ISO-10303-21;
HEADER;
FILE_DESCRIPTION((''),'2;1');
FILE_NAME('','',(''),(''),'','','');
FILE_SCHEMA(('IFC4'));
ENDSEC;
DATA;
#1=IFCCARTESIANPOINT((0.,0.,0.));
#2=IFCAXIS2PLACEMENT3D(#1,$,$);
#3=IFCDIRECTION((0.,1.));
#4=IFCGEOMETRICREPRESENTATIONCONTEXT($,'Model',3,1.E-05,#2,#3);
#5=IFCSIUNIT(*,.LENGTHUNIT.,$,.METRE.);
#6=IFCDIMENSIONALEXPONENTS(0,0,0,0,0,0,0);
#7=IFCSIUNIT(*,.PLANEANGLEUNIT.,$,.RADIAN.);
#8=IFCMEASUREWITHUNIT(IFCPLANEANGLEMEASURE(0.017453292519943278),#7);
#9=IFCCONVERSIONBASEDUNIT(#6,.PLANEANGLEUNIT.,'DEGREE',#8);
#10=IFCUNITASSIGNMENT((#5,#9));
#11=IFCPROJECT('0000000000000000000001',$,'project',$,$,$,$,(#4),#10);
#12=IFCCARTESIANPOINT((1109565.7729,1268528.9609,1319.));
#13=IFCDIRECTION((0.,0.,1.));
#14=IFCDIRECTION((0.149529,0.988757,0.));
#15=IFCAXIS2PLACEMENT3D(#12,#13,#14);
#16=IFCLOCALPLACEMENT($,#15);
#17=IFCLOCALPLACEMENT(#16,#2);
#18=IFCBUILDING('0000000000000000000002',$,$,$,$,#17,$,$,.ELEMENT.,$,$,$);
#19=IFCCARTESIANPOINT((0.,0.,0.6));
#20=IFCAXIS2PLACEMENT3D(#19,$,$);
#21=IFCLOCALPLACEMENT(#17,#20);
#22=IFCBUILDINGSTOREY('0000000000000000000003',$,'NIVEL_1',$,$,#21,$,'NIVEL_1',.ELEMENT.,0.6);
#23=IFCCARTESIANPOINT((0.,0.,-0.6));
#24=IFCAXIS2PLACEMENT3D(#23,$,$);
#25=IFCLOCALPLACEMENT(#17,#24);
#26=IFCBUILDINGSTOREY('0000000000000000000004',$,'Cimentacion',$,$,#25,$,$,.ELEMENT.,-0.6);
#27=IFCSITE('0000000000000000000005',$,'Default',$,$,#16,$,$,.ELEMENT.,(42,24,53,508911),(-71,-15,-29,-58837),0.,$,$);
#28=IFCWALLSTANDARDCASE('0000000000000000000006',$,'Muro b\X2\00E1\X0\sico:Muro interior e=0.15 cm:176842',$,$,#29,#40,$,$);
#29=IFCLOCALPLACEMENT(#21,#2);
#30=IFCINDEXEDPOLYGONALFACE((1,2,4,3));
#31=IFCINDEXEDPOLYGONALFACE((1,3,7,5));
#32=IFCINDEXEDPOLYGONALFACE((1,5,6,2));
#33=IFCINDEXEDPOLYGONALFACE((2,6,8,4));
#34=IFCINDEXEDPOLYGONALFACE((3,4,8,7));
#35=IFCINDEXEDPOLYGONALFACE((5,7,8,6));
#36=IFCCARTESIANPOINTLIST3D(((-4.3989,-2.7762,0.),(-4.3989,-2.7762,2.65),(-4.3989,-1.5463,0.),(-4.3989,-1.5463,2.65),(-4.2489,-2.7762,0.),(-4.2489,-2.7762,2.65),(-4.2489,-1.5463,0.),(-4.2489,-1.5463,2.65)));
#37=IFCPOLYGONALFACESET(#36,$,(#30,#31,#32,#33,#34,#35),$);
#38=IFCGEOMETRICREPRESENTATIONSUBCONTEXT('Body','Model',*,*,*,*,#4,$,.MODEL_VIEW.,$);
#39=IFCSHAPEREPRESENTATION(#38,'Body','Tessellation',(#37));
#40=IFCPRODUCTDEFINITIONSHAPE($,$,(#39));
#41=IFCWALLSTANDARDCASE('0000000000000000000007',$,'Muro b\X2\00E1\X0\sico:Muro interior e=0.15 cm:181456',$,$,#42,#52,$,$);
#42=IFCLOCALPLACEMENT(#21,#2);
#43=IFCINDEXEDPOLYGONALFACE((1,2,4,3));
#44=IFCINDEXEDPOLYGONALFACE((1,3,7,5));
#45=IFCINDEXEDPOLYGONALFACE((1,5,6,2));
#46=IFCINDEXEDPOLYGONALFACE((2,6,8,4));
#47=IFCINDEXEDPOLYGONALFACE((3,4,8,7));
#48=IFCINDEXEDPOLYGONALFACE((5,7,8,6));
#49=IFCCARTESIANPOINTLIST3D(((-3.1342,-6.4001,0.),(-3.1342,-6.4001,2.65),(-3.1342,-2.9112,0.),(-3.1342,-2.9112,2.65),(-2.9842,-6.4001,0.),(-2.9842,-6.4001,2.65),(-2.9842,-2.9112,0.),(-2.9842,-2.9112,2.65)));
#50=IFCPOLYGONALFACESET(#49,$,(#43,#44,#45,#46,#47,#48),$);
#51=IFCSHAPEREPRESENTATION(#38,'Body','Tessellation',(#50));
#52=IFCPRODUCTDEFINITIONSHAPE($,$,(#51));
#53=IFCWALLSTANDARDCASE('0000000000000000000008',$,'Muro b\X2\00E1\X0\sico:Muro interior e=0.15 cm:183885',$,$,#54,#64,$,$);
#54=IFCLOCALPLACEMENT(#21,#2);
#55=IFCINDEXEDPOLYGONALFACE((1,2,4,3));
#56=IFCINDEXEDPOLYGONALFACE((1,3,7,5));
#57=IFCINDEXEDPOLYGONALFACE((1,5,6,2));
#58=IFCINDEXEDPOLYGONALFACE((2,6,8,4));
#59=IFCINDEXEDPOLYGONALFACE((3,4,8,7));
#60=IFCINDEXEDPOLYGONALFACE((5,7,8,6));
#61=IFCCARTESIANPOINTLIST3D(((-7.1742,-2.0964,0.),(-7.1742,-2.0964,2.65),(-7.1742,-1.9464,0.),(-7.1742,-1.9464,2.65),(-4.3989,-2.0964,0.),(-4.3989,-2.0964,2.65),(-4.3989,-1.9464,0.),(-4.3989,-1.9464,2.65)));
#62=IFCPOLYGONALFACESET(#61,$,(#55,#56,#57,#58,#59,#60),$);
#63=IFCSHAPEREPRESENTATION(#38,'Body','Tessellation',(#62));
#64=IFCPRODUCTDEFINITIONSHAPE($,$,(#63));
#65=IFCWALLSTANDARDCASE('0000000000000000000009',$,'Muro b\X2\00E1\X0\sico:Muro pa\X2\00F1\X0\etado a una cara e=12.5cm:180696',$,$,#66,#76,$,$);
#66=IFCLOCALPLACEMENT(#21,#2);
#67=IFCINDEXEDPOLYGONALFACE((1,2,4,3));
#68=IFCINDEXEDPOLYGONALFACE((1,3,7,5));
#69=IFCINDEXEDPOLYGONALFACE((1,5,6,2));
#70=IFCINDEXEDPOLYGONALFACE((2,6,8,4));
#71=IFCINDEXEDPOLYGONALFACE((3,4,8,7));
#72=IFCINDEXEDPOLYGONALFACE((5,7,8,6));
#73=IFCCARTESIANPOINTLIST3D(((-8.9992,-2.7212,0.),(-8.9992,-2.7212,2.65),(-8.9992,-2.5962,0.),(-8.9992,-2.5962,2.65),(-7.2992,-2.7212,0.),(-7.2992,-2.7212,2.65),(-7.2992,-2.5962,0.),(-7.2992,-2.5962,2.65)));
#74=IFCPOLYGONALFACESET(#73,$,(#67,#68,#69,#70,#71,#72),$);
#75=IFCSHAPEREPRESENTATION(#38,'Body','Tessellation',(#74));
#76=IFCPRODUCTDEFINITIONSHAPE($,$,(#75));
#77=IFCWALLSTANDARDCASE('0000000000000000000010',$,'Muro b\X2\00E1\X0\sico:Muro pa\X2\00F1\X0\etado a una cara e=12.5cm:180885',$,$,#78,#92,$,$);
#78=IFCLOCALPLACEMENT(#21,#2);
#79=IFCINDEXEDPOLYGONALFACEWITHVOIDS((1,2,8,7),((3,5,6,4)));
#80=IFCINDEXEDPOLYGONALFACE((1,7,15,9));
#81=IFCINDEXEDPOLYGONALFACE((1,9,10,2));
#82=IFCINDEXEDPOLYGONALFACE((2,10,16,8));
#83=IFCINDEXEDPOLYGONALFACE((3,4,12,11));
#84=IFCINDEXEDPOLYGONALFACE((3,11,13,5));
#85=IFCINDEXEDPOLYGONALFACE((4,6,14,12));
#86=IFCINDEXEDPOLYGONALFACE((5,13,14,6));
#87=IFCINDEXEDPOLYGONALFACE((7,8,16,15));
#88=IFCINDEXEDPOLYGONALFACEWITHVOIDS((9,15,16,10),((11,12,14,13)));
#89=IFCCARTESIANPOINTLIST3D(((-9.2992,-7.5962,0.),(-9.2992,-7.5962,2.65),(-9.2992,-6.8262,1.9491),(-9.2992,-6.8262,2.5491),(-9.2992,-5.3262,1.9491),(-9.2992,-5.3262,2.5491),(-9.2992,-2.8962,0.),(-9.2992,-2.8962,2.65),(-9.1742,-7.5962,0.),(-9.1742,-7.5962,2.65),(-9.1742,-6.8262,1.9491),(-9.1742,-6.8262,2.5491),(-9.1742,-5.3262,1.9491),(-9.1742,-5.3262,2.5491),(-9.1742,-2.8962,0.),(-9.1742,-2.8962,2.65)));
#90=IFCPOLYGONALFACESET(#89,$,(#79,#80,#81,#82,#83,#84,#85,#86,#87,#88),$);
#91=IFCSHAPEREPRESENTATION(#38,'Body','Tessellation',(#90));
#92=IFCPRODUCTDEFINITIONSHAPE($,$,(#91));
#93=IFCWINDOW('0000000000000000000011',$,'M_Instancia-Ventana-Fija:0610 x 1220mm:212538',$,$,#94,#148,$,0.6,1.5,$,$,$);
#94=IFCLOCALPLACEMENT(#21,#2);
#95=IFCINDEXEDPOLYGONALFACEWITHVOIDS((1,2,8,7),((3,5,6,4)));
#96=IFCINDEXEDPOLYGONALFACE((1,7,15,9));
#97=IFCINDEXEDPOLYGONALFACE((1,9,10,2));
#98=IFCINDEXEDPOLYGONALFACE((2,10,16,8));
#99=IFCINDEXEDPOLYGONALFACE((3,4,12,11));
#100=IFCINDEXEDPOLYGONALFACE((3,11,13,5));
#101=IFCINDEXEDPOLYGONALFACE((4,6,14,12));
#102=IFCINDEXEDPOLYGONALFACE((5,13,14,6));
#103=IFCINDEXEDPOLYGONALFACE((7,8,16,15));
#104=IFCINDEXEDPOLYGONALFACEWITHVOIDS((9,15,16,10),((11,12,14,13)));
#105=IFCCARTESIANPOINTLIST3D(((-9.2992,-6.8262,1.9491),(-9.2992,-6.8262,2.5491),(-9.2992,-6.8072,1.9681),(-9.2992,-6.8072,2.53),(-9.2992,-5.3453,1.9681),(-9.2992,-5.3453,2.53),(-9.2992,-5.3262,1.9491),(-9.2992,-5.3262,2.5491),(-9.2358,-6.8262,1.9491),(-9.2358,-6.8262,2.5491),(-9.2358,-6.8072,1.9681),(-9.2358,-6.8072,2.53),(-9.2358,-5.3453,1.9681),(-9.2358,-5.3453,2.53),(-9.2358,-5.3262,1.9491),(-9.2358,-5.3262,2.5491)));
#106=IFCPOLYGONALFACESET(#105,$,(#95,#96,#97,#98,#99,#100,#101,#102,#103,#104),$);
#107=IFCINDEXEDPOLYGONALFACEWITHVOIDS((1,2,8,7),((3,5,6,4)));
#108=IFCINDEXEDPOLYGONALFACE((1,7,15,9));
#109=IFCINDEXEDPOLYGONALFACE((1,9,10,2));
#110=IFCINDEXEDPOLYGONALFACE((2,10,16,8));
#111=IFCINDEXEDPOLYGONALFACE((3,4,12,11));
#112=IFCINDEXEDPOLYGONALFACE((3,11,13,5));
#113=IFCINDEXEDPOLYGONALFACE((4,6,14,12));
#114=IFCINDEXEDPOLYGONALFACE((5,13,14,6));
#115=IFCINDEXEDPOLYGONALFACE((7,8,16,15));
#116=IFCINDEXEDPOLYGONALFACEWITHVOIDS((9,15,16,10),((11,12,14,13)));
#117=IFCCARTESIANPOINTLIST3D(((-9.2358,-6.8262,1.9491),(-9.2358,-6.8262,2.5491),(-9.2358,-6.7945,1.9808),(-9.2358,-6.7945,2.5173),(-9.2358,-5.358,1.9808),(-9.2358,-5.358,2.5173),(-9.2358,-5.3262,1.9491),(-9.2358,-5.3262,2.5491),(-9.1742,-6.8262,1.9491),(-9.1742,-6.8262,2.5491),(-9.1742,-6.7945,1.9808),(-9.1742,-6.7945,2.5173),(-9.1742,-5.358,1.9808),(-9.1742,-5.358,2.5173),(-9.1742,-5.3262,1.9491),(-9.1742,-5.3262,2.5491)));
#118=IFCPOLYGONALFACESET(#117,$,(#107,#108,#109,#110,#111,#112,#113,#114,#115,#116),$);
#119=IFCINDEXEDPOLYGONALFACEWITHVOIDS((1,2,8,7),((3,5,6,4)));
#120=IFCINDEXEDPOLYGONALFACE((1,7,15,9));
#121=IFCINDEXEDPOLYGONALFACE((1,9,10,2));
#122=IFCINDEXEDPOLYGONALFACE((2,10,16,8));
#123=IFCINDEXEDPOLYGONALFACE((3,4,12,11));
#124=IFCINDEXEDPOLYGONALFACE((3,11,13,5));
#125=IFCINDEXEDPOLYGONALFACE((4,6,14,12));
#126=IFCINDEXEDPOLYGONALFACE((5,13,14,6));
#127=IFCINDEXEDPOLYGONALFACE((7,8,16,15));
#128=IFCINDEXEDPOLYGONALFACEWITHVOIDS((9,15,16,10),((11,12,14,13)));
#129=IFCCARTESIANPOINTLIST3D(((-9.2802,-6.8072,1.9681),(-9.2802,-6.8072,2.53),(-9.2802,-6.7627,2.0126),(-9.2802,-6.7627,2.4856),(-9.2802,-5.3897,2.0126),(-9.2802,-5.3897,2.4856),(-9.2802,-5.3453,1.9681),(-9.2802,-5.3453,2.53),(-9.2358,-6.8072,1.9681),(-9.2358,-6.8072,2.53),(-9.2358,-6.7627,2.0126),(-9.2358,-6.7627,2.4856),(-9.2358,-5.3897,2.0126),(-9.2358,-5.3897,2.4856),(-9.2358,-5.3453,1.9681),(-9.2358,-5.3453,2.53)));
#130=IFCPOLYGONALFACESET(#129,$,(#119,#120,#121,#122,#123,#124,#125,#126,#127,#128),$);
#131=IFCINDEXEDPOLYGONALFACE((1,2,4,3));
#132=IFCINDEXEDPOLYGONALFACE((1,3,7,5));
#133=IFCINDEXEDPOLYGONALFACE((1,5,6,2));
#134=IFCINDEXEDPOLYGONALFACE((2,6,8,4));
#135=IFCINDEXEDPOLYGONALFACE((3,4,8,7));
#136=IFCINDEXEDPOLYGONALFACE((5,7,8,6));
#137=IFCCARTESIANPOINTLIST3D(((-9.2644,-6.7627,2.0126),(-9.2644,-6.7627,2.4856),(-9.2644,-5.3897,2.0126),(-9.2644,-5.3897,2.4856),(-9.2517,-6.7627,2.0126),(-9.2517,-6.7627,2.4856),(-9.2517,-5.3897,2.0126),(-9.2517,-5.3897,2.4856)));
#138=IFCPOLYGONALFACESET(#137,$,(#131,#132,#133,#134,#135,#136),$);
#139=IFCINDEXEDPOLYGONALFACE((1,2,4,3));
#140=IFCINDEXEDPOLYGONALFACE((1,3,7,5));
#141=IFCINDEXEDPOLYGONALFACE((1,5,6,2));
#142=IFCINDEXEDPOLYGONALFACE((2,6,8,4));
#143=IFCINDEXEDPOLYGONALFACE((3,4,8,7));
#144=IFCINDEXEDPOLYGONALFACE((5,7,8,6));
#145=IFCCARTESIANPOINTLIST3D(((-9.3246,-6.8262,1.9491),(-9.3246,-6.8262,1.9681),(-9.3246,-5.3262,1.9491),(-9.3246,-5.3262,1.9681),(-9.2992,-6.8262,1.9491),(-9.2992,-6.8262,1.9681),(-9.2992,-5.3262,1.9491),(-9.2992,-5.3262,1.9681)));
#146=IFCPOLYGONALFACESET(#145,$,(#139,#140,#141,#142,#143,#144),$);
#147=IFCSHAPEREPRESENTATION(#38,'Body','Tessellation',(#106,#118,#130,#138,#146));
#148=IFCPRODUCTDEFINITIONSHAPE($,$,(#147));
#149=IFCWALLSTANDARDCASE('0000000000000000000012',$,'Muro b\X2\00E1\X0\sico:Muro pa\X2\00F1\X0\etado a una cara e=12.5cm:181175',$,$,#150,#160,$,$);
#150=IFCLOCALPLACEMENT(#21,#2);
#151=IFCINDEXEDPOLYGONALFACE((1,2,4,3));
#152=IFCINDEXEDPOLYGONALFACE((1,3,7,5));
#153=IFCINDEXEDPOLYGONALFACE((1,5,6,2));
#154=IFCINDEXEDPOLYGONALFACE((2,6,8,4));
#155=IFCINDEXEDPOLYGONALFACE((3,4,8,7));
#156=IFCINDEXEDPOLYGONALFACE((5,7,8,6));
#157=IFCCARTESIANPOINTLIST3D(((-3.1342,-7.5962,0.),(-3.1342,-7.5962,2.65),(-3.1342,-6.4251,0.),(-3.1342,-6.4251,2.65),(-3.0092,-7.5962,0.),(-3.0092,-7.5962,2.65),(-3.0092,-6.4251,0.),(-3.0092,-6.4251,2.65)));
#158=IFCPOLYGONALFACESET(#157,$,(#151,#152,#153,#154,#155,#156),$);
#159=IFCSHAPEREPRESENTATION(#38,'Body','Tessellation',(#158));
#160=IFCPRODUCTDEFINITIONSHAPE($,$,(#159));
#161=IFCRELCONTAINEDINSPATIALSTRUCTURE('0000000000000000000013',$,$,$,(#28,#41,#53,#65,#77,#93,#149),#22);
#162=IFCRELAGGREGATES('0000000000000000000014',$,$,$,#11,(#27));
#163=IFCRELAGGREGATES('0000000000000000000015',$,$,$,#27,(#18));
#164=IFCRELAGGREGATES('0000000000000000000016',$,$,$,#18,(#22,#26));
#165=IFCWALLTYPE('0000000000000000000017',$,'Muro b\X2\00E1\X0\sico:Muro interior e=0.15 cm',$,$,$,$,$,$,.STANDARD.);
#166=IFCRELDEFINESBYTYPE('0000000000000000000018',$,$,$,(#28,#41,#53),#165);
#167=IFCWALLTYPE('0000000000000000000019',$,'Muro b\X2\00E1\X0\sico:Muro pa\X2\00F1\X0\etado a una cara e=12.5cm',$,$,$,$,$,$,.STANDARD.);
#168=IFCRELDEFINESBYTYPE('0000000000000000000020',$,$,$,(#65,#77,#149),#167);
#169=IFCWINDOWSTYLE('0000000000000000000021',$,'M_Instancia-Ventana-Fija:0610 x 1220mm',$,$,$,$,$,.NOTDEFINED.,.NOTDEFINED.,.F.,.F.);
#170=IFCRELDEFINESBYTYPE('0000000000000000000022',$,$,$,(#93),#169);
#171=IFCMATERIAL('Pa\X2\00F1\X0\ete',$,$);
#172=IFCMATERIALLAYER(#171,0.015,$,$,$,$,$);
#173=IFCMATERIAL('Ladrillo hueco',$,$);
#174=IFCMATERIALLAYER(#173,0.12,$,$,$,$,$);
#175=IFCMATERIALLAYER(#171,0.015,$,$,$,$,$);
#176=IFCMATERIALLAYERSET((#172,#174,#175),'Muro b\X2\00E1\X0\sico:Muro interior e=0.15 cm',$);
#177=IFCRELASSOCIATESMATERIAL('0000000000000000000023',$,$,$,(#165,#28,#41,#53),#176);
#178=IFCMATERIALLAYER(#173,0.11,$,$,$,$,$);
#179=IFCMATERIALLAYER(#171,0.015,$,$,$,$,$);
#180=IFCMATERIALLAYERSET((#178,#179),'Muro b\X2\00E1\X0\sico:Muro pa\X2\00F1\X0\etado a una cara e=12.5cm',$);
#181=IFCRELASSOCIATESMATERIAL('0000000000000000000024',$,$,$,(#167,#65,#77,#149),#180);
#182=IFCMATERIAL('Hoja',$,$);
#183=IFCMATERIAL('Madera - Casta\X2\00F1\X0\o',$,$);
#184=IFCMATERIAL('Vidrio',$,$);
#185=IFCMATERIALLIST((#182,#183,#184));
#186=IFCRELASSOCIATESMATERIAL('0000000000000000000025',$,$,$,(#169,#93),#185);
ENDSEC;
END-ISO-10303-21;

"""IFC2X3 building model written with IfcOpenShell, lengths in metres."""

from ifc_helpers import new_model, entity, si_unit, converted_unit, direction, frame, frame_2d, origin, origin_2d_with_axis, place, context, subcontext, project, spatial, polyline, rectangle, outline, extrude, source, transform, mapped, material, material_list, layer, layer_set, layer_usage, type_object, type_shapes, element, fill, save


model = new_model("IFC2X3")

# Units and contexts
model_context = context("Model", 3, precision=1e-05, world=origin(), true_north=direction((0.0, 1.0)))
body_context = subcontext(model_context, "Body", "Model", "MODEL_VIEW")
ifc_project = project(units=[si_unit("LENGTHUNIT", "METRE"), converted_unit("PLANEANGLEUNIT", "DEGREE", entity("IfcPlaneAngleMeasure", 0.017453292519943278), si_unit("PLANEANGLEUNIT", "RADIAN"), dimensions=[0, 0, 0, 0, 0, 0, 0])], contexts=[model_context])

# Site, building, storey
site_placement = place(None, frame((1109565.7729, 1268528.9609, 1319.0), z_axis=(0.0, 0.0, 1.0), x_axis=(0.149529, 0.988757, 0.0)))
site = spatial("IfcSite", under=ifc_project, at=site_placement, Name="Default", CompositionType="ELEMENT", RefLatitude=(42, 24, 53, 508911), RefLongitude=(-71, -15, -29, -58837), RefElevation=0.0)
building_placement = place(site_placement, origin())
building = spatial("IfcBuilding", under=site, at=building_placement, CompositionType="ELEMENT")
storey_1_placement = place(building_placement, frame((0.0, 0.0, 0.6)))
storey_1 = spatial("IfcBuildingStorey", under=building, at=storey_1_placement, Name="NIVEL_1", LongName="NIVEL_1", CompositionType="ELEMENT", Elevation=0.6)

# Walls
ifc_material_1 = material(Name="Pañete")
ifc_layer_1 = layer(ifc_material_1, 0.015)
ifc_material_2 = material(Name="Ladrillo hueco")
ifc_layer_2 = layer(ifc_material_2, 0.12)
ifc_layer_3 = layer(ifc_material_1, 0.015)
ifc_layer_set_1 = layer_set([ifc_layer_1, ifc_layer_2, ifc_layer_3], Name="Muro básico:Muro interior e=0.15 cm")
ifc_layer_usage_1 = layer_usage(ifc_layer_set_1, "AXIS2", "POSITIVE", -0.075)
wall_type_1 = type_object("IfcWallType", Name="Muro básico:Muro interior e=0.15 cm", PredefinedType="STANDARD", material=ifc_layer_set_1)
wall_1_placement = place(storey_1_placement, frame((-4.3239, -2.7762, 0.0), z_axis=(0.0, 0.0, 1.0), x_axis=(0.0, 1.0, 0.0)))
element("IfcWallStandardCase", 1, at=wall_1_placement, inside=storey_1, type_object=wall_type_1, material=ifc_layer_usage_1, Name="Muro básico:Muro interior e=0.15 cm:176842", context=body_context, shape_type="SweptSolid", body=[
    extrude(rectangle(XDim=1.2299, YDim=0.15, at=frame_2d((0.6149, 0.0), x_axis=(-1.0, 0.0))), origin(), (0.0, 0.0, 1.0), 2.65),
])
ifc_layer_usage_2 = layer_usage(ifc_layer_set_1, "AXIS2", "POSITIVE", -0.075)
wall_2_placement = place(storey_1_placement, frame((-3.0592, -6.4001, 0.0), z_axis=(0.0, 0.0, 1.0), x_axis=(0.0, 1.0, 0.0)))
element("IfcWallStandardCase", 2, at=wall_2_placement, inside=storey_1, type_object=wall_type_1, material=ifc_layer_usage_2, Name="Muro básico:Muro interior e=0.15 cm:181456", context=body_context, shape_type="SweptSolid", body=[
    extrude(rectangle(XDim=3.4889, YDim=0.15, at=frame_2d((1.7445, 0.0), x_axis=(-1.0, 0.0))), origin(), (0.0, 0.0, 1.0), 2.65),
])
ifc_layer_usage_3 = layer_usage(ifc_layer_set_1, "AXIS2", "NEGATIVE", 0.075)
wall_3_placement = place(storey_1_placement, frame((-4.3989, -2.0214, 0.0), z_axis=(0.0, 0.0, 1.0), x_axis=(-1.0, 0.0, 0.0)))
element("IfcWallStandardCase", 3, at=wall_3_placement, inside=storey_1, type_object=wall_type_1, material=ifc_layer_usage_3, Name="Muro básico:Muro interior e=0.15 cm:183885", context=body_context, shape_type="SweptSolid", body=[
    extrude(rectangle(XDim=2.7754, YDim=0.15, at=frame_2d((1.3877, 0.0), x_axis=(-1.0, 0.0))), origin(), (0.0, 0.0, 1.0), 2.65),
])
ifc_layer_4 = layer(ifc_material_2, 0.11)
ifc_layer_5 = layer(ifc_material_1, 0.015)
ifc_layer_set_2 = layer_set([ifc_layer_4, ifc_layer_5], Name="Muro básico:Muro pañetado a una cara e=12.5cm")
ifc_layer_usage_4 = layer_usage(ifc_layer_set_2, "AXIS2", "POSITIVE", -0.0625)
wall_type_2 = type_object("IfcWallType", Name="Muro básico:Muro pañetado a una cara e=12.5cm", PredefinedType="STANDARD", material=ifc_layer_set_2)
wall_4_placement = place(storey_1_placement, frame((-7.2992, -2.6587, 0.0), z_axis=(0.0, 0.0, 1.0), x_axis=(-1.0, 0.0, 0.0)))
element("IfcWallStandardCase", 4, at=wall_4_placement, inside=storey_1, type_object=wall_type_2, material=ifc_layer_usage_4, Name="Muro básico:Muro pañetado a una cara e=12.5cm:180696", context=body_context, shape_type="SweptSolid", body=[
    extrude(rectangle(XDim=1.7, YDim=0.125, at=frame_2d((0.85, 0.0), x_axis=(-1.0, 0.0))), origin(), (0.0, 0.0, 1.0), 2.65),
])

# Wall, opening, window
ifc_layer_usage_5 = layer_usage(ifc_layer_set_2, "AXIS2", "POSITIVE", -0.0625)
wall_5_placement = place(storey_1_placement, frame((-9.2367, -2.8962, 0.0), z_axis=(0.0, 0.0, 1.0), x_axis=(0.0, -1.0, 0.0)))
wall_5 = element("IfcWallStandardCase", 5, at=wall_5_placement, inside=storey_1, type_object=wall_type_2, material=ifc_layer_usage_5, Name="Muro básico:Muro pañetado a una cara e=12.5cm:180885", context=body_context, shape_type="SweptSolid", body=[
    extrude(rectangle(XDim=4.7, YDim=0.125, at=frame_2d((2.35, 0.0), x_axis=(-1.0, 0.0))), origin(), (0.0, 0.0, 1.0), 2.65),
])
opening_1_placement = place(wall_5_placement, frame((3.93, 0.0625, 1.9491)))
opening_1 = element("IfcOpeningElement", 6, at=opening_1_placement, cuts=wall_5, ObjectType="Opening", context=body_context, shape_type="SweptSolid", body=[
    extrude(rectangle(XDim=0.6, YDim=1.5, at=frame_2d((0.3, 0.75), x_axis=(-1.0, 0.0))), frame((0.0, 0.0, 0.0), z_axis=(0.0, -1.0, 0.0), x_axis=(0.0, 0.0, 1.0)), (0.0, 0.0, 1.0), 0.125),
])
ifc_material_3 = material(Name="Hoja")
ifc_material_4 = material(Name="Madera - Castaño")
ifc_material_5 = material(Name="Vidrio")
ifc_material_list = material_list([ifc_material_3, ifc_material_4, ifc_material_5])
window_style = type_object("IfcWindowStyle", Name="M_Instancia-Ventana-Fija:0610 x 1220mm", ConstructionType="NOTDEFINED", OperationType="NOTDEFINED", ParameterTakesPrecedence=False, Sizeable=False, material=ifc_material_list)
shared_shape_1 = source(origin(), body_context, "Body", "SweptSolid", [
    extrude(outline(polyline([(-0.3, -0.75), (0.3, -0.75), (0.3, 0.75), (-0.3, 0.75), (-0.3, -0.75)]), holes=[polyline([(-0.2809, -0.7309), (-0.2809, 0.731), (0.281, 0.731), (0.281, -0.7309), (-0.2809, -0.7309)])]), frame((0.75, 0.0616, 0.3), z_axis=(0.0, 1.0, 0.0), x_axis=(0.0, 0.0, -1.0)), (0.0, 0.0, 1.0), 0.0635),
    extrude(outline(polyline([(-0.75, -0.3), (0.75, -0.3), (0.75, 0.3), (-0.75, 0.3), (-0.75, -0.3)]), holes=[polyline([(-0.7183, -0.2682), (-0.7183, 0.2683), (0.7182, 0.2683), (0.7182, -0.2682), (-0.7183, -0.2682)])]), frame((0.75, 0.0, 0.3), z_axis=(0.0, 1.0, 0.0), x_axis=(1.0, 0.0, 0.0)), (0.0, 0.0, 1.0), 0.0616),
    extrude(outline(polyline([(-0.7309, -0.281), (0.7309, -0.281), (0.7309, 0.281), (-0.7309, 0.281), (-0.7309, -0.281)]), holes=[polyline([(-0.6865, -0.2365), (-0.6865, 0.2365), (0.6865, 0.2365), (0.6865, -0.2365), (-0.6865, -0.2365)])]), frame((0.75, 0.0616, 0.3), z_axis=(0.0, 1.0, 0.0), x_axis=(1.0, 0.0, 0.0)), (0.0, 0.0, 1.0), 0.0444),
    extrude(rectangle(XDim=0.0127, YDim=1.373, at=origin_2d_with_axis()), frame((0.75, 0.0838, 0.0635), z_axis=(0.0, 0.0, 1.0), x_axis=(0.0, 1.0, 0.0)), (0.0, 0.0, 1.0), 0.473),
    extrude(rectangle(XDim=0.0254, YDim=1.5, at=origin_2d_with_axis()), frame((0.75, 0.1377, 0.0), z_axis=(0.0, 0.0, 1.0), x_axis=(0.0, -1.0, 0.0)), (0.0, 0.0, 1.0), 0.019),
])
type_shapes(window_style, [shared_shape_1])
window_placement = place(opening_1_placement, frame((0.0, 0.0, 0.0), z_axis=(0.0, 0.0, 1.0), x_axis=(-1.0, 0.0, 0.0)))
window = element("IfcWindow", 7, at=window_placement, inside=storey_1, type_object=window_style, material=ifc_material_list, Name="M_Instancia-Ventana-Fija:0610 x 1220mm:212538", OverallHeight=0.6, OverallWidth=1.5, context=body_context, shape_type="MappedRepresentation", body=[
    mapped(shared_shape_1, transform((0.0, 0.0, 0.0), scale=1.0)),
])
fill(opening_1, window)

# Wall
ifc_layer_usage_6 = layer_usage(ifc_layer_set_2, "AXIS2", "POSITIVE", -0.0625)
wall_6_placement = place(storey_1_placement, frame((-3.0717, -7.5962, 0.0), z_axis=(0.0, 0.0, 1.0), x_axis=(0.0, 1.0, 0.0)))
element("IfcWallStandardCase", 8, at=wall_6_placement, inside=storey_1, type_object=wall_type_2, material=ifc_layer_usage_6, Name="Muro básico:Muro pañetado a una cara e=12.5cm:181175", context=body_context, shape_type="SweptSolid", body=[
    extrude(rectangle(XDim=1.1711, YDim=0.125, at=frame_2d((0.5855, 0.0), x_axis=(-1.0, 0.0))), origin(), (0.0, 0.0, 1.0), 2.65),
])

# Shared definitions
storey_2_placement = place(building_placement, frame((0.0, 0.0, -0.6)))
storey_2 = spatial("IfcBuildingStorey", under=building, at=storey_2_placement, Name="Cimentacion", CompositionType="ELEMENT", Elevation=-0.6)

save(model, "model.ifc")
